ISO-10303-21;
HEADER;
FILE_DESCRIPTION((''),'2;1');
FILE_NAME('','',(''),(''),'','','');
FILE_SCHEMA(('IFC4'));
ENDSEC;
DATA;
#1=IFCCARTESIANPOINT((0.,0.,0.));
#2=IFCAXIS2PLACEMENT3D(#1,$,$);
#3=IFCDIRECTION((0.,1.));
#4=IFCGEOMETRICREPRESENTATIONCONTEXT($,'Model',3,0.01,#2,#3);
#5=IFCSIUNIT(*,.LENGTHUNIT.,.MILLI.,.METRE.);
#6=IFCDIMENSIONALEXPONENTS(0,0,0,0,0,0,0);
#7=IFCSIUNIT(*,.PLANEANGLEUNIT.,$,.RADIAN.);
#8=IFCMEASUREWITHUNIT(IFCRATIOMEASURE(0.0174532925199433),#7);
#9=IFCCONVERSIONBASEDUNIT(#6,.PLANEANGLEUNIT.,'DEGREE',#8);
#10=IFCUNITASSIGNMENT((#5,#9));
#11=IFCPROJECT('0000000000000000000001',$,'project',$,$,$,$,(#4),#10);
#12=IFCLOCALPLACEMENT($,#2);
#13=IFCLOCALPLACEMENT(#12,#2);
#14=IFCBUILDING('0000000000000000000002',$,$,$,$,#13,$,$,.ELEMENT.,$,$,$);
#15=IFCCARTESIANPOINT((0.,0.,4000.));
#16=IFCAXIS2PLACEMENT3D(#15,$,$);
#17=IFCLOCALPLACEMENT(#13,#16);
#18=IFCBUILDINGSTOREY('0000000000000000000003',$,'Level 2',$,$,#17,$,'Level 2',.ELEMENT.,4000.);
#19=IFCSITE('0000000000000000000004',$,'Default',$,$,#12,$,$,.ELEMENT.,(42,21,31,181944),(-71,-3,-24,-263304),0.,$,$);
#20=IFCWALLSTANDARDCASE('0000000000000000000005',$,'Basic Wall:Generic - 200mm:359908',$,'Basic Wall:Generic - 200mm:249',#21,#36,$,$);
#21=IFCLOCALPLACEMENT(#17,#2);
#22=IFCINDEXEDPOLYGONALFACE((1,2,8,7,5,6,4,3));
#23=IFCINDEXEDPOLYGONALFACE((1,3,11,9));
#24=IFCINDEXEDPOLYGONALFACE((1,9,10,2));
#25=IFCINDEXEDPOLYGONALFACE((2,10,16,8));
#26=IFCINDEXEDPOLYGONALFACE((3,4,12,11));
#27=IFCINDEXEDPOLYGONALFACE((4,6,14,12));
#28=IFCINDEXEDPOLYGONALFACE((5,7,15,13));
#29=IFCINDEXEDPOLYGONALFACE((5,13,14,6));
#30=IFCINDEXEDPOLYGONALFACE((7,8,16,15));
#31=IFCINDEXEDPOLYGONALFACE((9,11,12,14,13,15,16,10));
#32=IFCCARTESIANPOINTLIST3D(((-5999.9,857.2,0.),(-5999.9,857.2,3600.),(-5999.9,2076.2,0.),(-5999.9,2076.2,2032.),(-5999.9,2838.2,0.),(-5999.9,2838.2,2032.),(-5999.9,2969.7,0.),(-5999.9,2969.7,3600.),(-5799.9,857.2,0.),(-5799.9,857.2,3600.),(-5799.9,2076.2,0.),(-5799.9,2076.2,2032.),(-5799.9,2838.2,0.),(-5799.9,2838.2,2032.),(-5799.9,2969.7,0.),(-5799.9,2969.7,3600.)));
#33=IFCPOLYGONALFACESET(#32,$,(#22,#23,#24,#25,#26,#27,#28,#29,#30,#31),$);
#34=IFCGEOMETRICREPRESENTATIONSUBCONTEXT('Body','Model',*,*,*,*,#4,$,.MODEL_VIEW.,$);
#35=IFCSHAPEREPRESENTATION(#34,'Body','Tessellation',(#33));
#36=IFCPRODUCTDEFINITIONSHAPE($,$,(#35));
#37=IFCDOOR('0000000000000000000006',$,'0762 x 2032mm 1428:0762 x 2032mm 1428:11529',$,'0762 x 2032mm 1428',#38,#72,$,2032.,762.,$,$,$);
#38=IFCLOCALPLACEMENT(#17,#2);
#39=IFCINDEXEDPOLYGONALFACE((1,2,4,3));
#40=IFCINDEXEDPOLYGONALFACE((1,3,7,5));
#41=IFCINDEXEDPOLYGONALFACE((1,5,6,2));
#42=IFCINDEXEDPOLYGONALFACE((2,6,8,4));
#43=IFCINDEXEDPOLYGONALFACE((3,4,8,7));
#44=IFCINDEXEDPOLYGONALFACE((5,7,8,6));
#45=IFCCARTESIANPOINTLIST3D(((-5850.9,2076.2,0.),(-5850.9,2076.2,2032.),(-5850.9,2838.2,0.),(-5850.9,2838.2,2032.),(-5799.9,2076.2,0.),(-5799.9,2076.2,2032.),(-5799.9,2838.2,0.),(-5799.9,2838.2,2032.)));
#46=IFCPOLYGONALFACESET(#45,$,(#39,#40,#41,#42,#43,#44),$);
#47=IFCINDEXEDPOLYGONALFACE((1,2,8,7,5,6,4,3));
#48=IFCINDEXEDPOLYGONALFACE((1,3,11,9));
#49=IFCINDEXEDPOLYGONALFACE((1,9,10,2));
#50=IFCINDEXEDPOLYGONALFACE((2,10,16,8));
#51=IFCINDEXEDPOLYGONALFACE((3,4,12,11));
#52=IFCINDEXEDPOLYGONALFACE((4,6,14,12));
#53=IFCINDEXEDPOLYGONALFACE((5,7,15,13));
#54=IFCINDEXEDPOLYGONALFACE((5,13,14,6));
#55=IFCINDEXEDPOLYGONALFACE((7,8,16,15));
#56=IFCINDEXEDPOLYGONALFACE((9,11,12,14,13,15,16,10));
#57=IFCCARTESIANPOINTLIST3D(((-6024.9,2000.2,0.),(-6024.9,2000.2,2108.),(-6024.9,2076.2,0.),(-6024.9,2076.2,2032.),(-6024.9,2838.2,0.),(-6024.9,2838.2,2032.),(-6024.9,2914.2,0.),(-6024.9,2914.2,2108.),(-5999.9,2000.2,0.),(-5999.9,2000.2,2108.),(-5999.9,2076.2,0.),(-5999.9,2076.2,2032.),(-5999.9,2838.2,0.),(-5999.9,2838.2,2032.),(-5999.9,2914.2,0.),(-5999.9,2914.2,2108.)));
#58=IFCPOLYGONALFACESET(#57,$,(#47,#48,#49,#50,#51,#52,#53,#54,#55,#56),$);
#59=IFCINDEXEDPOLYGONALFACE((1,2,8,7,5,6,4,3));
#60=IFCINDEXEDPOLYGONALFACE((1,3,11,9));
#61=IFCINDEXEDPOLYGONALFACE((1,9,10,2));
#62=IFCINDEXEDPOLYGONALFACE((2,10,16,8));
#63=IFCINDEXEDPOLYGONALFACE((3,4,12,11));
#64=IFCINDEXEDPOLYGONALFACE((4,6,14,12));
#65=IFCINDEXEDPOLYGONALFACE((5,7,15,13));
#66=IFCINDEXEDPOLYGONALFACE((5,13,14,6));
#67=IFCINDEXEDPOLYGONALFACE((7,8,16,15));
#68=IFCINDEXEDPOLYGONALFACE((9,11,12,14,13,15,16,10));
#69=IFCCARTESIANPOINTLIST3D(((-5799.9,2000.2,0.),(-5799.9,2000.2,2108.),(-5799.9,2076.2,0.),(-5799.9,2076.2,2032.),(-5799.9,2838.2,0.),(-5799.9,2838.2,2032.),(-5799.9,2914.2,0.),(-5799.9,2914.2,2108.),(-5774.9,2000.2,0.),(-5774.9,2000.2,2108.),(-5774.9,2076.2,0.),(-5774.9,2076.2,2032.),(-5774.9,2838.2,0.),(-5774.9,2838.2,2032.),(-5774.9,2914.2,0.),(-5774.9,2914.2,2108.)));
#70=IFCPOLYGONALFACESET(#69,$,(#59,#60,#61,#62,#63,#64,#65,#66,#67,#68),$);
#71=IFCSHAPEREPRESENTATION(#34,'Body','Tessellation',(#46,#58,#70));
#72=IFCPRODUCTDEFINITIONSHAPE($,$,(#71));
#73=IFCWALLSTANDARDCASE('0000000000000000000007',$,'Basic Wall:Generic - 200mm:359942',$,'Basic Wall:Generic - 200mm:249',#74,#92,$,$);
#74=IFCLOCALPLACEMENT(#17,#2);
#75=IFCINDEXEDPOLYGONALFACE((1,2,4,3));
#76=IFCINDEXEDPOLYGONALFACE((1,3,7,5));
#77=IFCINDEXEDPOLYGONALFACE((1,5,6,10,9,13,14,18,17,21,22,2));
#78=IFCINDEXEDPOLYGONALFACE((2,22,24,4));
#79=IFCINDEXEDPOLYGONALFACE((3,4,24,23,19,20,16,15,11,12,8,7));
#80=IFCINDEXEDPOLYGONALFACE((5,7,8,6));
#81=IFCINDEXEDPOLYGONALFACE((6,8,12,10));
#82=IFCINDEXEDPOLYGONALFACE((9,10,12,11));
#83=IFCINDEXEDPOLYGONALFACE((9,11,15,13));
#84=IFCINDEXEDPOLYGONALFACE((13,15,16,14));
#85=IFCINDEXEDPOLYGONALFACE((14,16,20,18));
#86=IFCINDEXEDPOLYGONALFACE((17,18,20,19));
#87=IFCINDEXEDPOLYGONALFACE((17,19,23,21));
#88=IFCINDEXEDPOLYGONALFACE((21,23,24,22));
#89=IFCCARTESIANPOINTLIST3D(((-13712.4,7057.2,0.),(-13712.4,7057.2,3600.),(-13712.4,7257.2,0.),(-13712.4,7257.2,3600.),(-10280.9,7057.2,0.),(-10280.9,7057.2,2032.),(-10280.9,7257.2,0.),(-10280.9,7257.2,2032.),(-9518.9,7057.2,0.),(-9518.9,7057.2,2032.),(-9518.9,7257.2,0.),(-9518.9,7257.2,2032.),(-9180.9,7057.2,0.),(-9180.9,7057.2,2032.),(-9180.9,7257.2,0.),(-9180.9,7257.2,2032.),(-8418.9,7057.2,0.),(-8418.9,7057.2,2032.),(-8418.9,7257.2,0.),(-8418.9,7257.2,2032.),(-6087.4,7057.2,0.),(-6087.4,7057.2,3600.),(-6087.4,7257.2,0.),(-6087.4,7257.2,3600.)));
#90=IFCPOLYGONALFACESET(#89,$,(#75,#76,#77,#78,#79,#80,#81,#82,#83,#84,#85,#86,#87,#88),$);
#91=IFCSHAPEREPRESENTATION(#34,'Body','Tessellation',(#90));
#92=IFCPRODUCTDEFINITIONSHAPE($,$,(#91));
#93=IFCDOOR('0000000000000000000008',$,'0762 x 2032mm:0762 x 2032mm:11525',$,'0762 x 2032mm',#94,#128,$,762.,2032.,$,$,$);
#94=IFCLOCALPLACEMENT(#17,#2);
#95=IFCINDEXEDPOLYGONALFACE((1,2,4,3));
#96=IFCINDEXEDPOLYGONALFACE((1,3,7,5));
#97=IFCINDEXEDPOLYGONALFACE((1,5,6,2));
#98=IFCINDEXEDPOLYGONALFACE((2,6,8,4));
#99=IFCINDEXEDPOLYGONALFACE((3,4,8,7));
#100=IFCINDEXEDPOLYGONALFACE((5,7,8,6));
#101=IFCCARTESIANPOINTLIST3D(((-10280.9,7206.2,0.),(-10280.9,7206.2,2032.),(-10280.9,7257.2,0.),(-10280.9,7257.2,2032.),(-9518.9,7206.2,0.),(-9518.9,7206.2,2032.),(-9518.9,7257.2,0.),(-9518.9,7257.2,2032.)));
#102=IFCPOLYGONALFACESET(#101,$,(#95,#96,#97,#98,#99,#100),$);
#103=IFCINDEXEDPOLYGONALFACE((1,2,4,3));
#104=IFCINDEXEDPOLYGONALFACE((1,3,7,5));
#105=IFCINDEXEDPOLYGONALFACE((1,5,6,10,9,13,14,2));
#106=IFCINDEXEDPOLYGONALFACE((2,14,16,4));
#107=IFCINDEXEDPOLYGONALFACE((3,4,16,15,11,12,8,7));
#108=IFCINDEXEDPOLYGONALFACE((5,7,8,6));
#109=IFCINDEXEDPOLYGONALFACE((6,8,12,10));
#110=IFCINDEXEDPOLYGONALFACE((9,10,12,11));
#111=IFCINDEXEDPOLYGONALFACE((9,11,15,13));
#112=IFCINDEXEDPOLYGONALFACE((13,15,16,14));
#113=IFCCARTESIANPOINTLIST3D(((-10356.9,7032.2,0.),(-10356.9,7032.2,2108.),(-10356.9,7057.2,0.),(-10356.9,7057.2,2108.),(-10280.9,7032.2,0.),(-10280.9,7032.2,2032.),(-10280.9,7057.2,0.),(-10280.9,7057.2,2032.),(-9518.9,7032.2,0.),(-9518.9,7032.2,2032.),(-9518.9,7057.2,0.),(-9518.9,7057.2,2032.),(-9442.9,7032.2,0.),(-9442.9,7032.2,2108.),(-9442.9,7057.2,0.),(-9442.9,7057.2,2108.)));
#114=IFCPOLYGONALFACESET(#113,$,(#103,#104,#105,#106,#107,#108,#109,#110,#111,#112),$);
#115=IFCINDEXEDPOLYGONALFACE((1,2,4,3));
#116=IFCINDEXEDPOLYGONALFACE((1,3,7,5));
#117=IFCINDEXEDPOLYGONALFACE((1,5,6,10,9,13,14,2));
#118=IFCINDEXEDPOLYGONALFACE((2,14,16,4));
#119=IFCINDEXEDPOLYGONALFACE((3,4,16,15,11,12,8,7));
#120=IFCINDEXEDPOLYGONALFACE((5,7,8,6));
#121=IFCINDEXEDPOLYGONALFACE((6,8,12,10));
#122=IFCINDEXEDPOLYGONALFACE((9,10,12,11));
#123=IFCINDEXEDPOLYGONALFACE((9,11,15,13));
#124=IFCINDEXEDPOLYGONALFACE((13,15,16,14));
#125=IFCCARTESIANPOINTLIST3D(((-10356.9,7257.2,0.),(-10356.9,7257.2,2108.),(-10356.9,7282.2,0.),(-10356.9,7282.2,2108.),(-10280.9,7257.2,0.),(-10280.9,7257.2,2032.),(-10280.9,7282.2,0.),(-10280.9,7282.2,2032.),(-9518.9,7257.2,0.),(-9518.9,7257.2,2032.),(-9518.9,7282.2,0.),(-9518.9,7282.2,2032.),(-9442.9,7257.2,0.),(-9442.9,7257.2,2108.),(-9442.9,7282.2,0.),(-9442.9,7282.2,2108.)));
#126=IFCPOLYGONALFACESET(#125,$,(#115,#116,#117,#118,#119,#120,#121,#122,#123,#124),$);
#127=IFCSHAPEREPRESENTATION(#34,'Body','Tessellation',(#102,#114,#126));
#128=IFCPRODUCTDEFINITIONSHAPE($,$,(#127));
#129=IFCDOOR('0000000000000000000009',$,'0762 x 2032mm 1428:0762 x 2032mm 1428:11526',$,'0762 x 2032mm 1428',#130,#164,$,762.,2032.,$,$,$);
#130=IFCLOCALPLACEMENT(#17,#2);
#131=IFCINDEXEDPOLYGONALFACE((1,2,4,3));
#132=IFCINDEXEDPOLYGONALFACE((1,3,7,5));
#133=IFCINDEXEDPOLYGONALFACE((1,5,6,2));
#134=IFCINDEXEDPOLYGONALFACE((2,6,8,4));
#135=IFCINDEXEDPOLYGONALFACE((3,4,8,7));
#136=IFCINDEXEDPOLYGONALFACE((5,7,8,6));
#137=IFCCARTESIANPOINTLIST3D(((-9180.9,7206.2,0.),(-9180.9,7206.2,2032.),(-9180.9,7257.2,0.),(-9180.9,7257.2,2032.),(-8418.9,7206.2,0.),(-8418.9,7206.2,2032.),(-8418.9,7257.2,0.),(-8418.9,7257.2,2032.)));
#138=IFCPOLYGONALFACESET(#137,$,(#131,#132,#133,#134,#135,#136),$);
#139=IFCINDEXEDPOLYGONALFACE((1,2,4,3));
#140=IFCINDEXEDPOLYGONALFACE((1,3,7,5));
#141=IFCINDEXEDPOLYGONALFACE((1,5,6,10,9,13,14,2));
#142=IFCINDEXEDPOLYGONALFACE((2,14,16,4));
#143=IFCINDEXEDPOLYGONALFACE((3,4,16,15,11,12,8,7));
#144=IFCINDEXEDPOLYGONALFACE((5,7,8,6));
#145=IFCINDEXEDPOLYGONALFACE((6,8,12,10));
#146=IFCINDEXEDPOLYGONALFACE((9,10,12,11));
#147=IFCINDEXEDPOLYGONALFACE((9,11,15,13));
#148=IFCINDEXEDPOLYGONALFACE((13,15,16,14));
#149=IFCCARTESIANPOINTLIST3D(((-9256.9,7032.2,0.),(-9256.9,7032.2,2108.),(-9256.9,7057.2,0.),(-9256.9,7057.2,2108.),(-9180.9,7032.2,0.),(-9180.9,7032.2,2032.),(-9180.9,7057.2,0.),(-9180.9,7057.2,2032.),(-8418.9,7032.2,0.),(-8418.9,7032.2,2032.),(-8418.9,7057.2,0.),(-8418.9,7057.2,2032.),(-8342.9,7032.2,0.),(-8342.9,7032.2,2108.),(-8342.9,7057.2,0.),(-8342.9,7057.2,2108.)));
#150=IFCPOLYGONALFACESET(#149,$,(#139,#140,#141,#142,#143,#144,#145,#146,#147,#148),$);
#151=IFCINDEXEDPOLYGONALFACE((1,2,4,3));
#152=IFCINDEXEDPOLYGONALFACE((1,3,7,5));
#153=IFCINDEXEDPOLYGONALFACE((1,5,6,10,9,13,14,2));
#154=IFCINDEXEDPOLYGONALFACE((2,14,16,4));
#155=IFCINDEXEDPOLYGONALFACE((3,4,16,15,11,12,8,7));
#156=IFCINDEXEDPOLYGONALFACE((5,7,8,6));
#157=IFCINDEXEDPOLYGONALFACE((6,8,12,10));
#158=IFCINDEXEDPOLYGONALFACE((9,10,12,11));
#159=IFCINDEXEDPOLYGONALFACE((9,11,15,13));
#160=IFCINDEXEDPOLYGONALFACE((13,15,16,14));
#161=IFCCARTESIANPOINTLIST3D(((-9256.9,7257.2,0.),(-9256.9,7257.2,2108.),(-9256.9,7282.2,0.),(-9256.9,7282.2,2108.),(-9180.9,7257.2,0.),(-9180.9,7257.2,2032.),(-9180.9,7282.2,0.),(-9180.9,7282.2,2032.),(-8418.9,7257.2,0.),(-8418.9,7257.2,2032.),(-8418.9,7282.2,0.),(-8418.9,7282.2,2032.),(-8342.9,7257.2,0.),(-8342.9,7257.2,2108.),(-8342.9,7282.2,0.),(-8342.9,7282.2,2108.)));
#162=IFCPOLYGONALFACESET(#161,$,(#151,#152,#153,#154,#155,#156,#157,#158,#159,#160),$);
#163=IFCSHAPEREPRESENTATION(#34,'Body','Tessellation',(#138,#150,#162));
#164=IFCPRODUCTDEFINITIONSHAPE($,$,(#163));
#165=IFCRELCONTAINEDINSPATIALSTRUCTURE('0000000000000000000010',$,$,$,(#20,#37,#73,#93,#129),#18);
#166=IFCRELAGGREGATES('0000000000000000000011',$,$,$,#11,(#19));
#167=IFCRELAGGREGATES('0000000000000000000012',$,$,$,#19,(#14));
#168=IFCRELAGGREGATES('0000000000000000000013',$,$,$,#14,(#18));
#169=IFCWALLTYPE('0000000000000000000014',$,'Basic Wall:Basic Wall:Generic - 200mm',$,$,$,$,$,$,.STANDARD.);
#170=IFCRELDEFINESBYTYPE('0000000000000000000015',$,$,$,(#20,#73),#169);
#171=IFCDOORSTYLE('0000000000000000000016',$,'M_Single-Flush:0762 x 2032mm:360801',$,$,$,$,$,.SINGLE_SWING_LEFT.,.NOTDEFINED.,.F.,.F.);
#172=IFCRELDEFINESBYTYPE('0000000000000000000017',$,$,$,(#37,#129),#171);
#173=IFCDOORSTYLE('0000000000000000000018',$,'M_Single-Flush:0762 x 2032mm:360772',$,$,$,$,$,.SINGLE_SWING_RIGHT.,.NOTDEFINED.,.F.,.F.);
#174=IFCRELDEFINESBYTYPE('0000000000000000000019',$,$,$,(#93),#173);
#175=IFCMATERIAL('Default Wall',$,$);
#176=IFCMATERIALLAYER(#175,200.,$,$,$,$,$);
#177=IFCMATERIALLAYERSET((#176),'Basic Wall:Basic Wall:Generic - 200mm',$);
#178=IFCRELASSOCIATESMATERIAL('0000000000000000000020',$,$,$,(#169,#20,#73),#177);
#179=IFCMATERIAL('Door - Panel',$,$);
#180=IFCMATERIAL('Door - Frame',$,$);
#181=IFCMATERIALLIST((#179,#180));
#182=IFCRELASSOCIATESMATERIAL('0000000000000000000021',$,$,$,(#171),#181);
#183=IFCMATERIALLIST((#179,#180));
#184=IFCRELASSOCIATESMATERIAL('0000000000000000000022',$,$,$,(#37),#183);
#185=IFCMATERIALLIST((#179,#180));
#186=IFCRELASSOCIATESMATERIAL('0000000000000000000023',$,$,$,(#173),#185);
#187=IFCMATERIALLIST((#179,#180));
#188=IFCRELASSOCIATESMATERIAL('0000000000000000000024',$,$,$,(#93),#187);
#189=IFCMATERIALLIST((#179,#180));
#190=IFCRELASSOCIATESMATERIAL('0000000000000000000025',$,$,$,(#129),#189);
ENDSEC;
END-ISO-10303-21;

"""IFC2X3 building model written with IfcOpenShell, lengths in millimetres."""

from ifc_helpers import new_model, entity, si_unit, converted_unit, direction, frame, frame_2d, origin, origin_2d_with_axis, place, context, subcontext, project, spatial, polyline, rectangle, outline, extrude, source, transform, mapped, material, material_list, layer, layer_set, layer_usage, type_object, type_shapes, element, fill, save


model = new_model("IFC2X3")

# Units and contexts
model_context = context("Model", 3, precision=0.01, world=origin(), true_north=direction((0.0, 1.0)))
body_context = subcontext(model_context, "Body", "Model", "MODEL_VIEW")
ifc_project = project(units=[si_unit("LENGTHUNIT", "METRE", prefix="MILLI"), converted_unit("PLANEANGLEUNIT", "DEGREE", entity("IfcRatioMeasure", 0.0174532925199433), si_unit("PLANEANGLEUNIT", "RADIAN"), dimensions=[0, 0, 0, 0, 0, 0, 0])], contexts=[model_context])

# Site, building, storey
site_placement = place(None, origin())
site = spatial("IfcSite", under=ifc_project, at=site_placement, Name="Default", CompositionType="ELEMENT", RefLatitude=(42, 21, 31, 181944), RefLongitude=(-71, -3, -24, -263304), RefElevation=0.0)
building_placement = place(site_placement, origin())
building = spatial("IfcBuilding", under=site, at=building_placement, CompositionType="ELEMENT")
storey_placement = place(building_placement, frame((0.0, 0.0, 4000.0)))
storey = spatial("IfcBuildingStorey", under=building, at=storey_placement, Name="Level 2", LongName="Level 2", CompositionType="ELEMENT", Elevation=4000.0)

# Shared definitions
ifc_material_1 = material(Name="Default Wall")
ifc_material_2 = material(Name="Door - Panel")
ifc_material_3 = material(Name="Door - Frame")

# Wall, opening, door
ifc_layer_1 = layer(ifc_material_1, 200.0)
ifc_layer_set_1 = layer_set([ifc_layer_1], Name="Basic Wall:Basic Wall:Generic - 200mm")
ifc_layer_usage_1 = layer_usage(ifc_layer_set_1, "AXIS2", "NEGATIVE", 100.0)
wall_type_1 = type_object("IfcWallType", Name="Basic Wall:Basic Wall:Generic - 200mm", PredefinedType="STANDARD", material=ifc_layer_set_1)
wall_1_placement = place(storey_placement, frame((-5899.9, 857.2, 0.0), z_axis=(0.0, 0.0, 1.0), x_axis=(0.0, 1.0, 0.0)))
wall_1 = element("IfcWallStandardCase", 1, at=wall_1_placement, inside=storey, type_object=wall_type_1, material=ifc_layer_usage_1, Name="Basic Wall:Generic - 200mm:359908", ObjectType="Basic Wall:Generic - 200mm:249", context=body_context, shape_type="SweptSolid", body=[
    extrude(rectangle(XDim=2112.5, YDim=200.0, at=frame_2d((1056.2, 0.0), x_axis=(-1.0, 0.0))), origin(), (0.0, 0.0, 1.0), 3600.0),
])
opening_1_placement = place(wall_1_placement, frame((-857.2, -5899.9, 0.0), z_axis=(0.0, 0.0, 1.0), x_axis=(0.0, -1.0, 0.0)))
opening_1 = element("IfcOpeningElement", 2, at=opening_1_placement, cuts=wall_1, ObjectType="Opening", context=body_context, shape_type="SweptSolid", body=[
    extrude(rectangle(XDim=2032.0, YDim=762.0, at=frame_2d((0.0, 0.0), x_axis=(0.0, 1.0))), frame((-5797.9, 2457.2, 1016.0), z_axis=(-1.0, 0.0, 0.0), x_axis=(0.0, -1.0, 0.0)), (0.0, 0.0, 1.0), 204.0),
])
ifc_material_list_1 = material_list([ifc_material_2, ifc_material_3])
ifc_material_list_2 = material_list([ifc_material_2, ifc_material_3])
door_style_1 = type_object("IfcDoorStyle", Name="M_Single-Flush:0762 x 2032mm:360801", ConstructionType="NOTDEFINED", OperationType="SINGLE_SWING_LEFT", ParameterTakesPrecedence=False, Sizeable=False, material=ifc_material_list_2)
shared_shape_1 = source(origin(), body_context, "Body", "SweptSolid", [
    extrude(rectangle(XDim=51.0, YDim=762.0, at=origin_2d_with_axis()), frame((381.0, -27.5, 0.0), z_axis=(0.0, 0.0, 1.0), x_axis=(0.0, 1.0, 0.0)), (0.0, 0.0, 1.0), 2032.0),
    extrude(outline(polyline([(-1035.0, -457.0), (1073.0, -457.0), (1073.0, 457.0), (-1035.0, 457.0), (-1035.0, 381.0), (997.0, 381.0), (997.0, -381.0), (-1035.0, -381.0), (-1035.0, -457.0)])), frame((381.0, -227.0, 1035.0), z_axis=(0.0, 1.0, 0.0), x_axis=(0.0, 0.0, 1.0)), (0.0, 0.0, 1.0), 25.0),
    extrude(outline(polyline([(-457.0, -1073.0), (457.0, -1073.0), (457.0, 1035.0), (381.0, 1035.0), (381.0, -997.0), (-381.0, -997.0), (-381.0, 1035.0), (-457.0, 1035.0), (-457.0, -1073.0)])), frame((381.0, -2.0, 1035.0), z_axis=(0.0, 1.0, 0.0), x_axis=(1.0, 0.0, 0.0)), (0.0, 0.0, 1.0), 25.0),
])
type_shapes(door_style_1, [shared_shape_1])
door_1_placement = place(opening_1_placement, frame((-5797.9, 2838.2, 0.0), z_axis=(0.0, 0.0, 1.0), x_axis=(0.0, -1.0, 0.0)))
door_1 = element("IfcDoor", 3, at=door_1_placement, inside=storey, type_object=door_style_1, material=ifc_material_list_1, Name="0762 x 2032mm 1428:0762 x 2032mm 1428:11529", ObjectType="0762 x 2032mm 1428", OverallHeight=2032.0, OverallWidth=762.0, context=body_context, shape_type="MappedRepresentation", body=[
    mapped(shared_shape_1, transform((0.0, 0.0, 0.0), scale=1.0)),
])
fill(opening_1, door_1)

# Wall, openings, doors
ifc_layer_usage_2 = layer_usage(ifc_layer_set_1, "AXIS2", "NEGATIVE", 100.0)
wall_2_placement = place(storey_placement, frame((-13712.4, 7157.2, 0.0)))
wall_2 = element("IfcWallStandardCase", 4, at=wall_2_placement, inside=storey, type_object=wall_type_1, material=ifc_layer_usage_2, Name="Basic Wall:Generic - 200mm:359942", ObjectType="Basic Wall:Generic - 200mm:249", context=body_context, shape_type="SweptSolid", body=[
    extrude(rectangle(XDim=7625.0, YDim=200.0, at=frame_2d((3812.5, 0.0), x_axis=(-1.0, 0.0))), origin(), (0.0, 0.0, 1.0), 3600.0),
])
opening_2_placement = place(wall_2_placement, frame((13712.4, -7157.2, 0.0)))
opening_2 = element("IfcOpeningElement", 5, at=opening_2_placement, cuts=wall_2, ObjectType="Opening", context=body_context, shape_type="SweptSolid", body=[
    extrude(rectangle(XDim=2032.0, YDim=762.0, at=frame_2d((0.0, 0.0), x_axis=(1.0, 0.0))), frame((-9899.9, 7055.2, 1016.0), z_axis=(0.0, 1.0, 0.0), x_axis=(0.0, 0.0, -1.0)), (0.0, 0.0, 1.0), 204.0),
])
opening_3_placement = place(wall_2_placement, frame((13712.4, -7157.2, 0.0)))
opening_3 = element("IfcOpeningElement", 6, at=opening_3_placement, cuts=wall_2, ObjectType="Opening", context=body_context, shape_type="SweptSolid", body=[
    extrude(rectangle(XDim=2032.0, YDim=762.0, at=frame_2d((0.0, 0.0), x_axis=(1.0, 0.0))), frame((-8799.9, 7055.2, 1016.0), z_axis=(0.0, 1.0, 0.0), x_axis=(0.0, 0.0, 1.0)), (0.0, 0.0, 1.0), 204.0),
])
ifc_material_list_3 = material_list([ifc_material_2, ifc_material_3])
ifc_material_list_4 = material_list([ifc_material_2, ifc_material_3])
door_style_2 = type_object("IfcDoorStyle", Name="M_Single-Flush:0762 x 2032mm:360772", ConstructionType="NOTDEFINED", OperationType="SINGLE_SWING_RIGHT", ParameterTakesPrecedence=False, Sizeable=False, material=ifc_material_list_4)
shared_shape_2 = source(origin(), body_context, "Body", "SweptSolid", [
    extrude(rectangle(XDim=762.0, YDim=51.0, at=frame_2d((0.0, 0.0), x_axis=(1.0, 0.0))), frame((381.0, -27.5, 0.0), z_axis=(0.0, 0.0, 1.0), x_axis=(-1.0, 0.0, 0.0)), (0.0, 0.0, 1.0), 2032.0),
    extrude(outline(polyline([(-457.0, -1035.0), (-381.0, -1035.0), (-381.0, 997.0), (381.0, 997.0), (381.0, -1035.0), (457.0, -1035.0), (457.0, 1073.0), (-457.0, 1073.0), (-457.0, -1035.0)])), frame((381.0, -227.0, 1035.0), z_axis=(0.0, 1.0, 0.0), x_axis=(-1.0, 0.0, 0.0)), (0.0, 0.0, 1.0), 25.0),
    extrude(outline(polyline([(-1073.0, -457.0), (1035.0, -457.0), (1035.0, -381.0), (-997.0, -381.0), (-997.0, 381.0), (1035.0, 381.0), (1035.0, 457.0), (-1073.0, 457.0), (-1073.0, -457.0)])), frame((381.0, -2.0, 1035.0), z_axis=(0.0, 1.0, 0.0), x_axis=(0.0, 0.0, -1.0)), (0.0, 0.0, 1.0), 25.0),
])
type_shapes(door_style_2, [shared_shape_2])
door_2_placement = place(opening_2_placement, frame((-10280.9, 7259.2, 0.0)))
door_2 = element("IfcDoor", 7, at=door_2_placement, inside=storey, type_object=door_style_2, material=ifc_material_list_3, Name="0762 x 2032mm:0762 x 2032mm:11525", ObjectType="0762 x 2032mm", OverallHeight=762.0, OverallWidth=2032.0, context=body_context, shape_type="MappedRepresentation", body=[
    mapped(shared_shape_2, transform((0.0, 0.0, 0.0), scale=1.0)),
])
fill(opening_2, door_2)
ifc_material_list_5 = material_list([ifc_material_2, ifc_material_3])
door_3_placement = place(opening_3_placement, frame((-9180.9, 7259.2, 0.0)))
door_3 = element("IfcDoor", 8, at=door_3_placement, inside=storey, type_object=door_style_1, material=ifc_material_list_5, Name="0762 x 2032mm 1428:0762 x 2032mm 1428:11526", ObjectType="0762 x 2032mm 1428", OverallHeight=762.0, OverallWidth=2032.0, context=body_context, shape_type="MappedRepresentation", body=[
    mapped(shared_shape_1, transform((0.0, 0.0, 0.0), scale=1.0)),
])
fill(opening_3, door_3)

save(model, "model.ifc")
